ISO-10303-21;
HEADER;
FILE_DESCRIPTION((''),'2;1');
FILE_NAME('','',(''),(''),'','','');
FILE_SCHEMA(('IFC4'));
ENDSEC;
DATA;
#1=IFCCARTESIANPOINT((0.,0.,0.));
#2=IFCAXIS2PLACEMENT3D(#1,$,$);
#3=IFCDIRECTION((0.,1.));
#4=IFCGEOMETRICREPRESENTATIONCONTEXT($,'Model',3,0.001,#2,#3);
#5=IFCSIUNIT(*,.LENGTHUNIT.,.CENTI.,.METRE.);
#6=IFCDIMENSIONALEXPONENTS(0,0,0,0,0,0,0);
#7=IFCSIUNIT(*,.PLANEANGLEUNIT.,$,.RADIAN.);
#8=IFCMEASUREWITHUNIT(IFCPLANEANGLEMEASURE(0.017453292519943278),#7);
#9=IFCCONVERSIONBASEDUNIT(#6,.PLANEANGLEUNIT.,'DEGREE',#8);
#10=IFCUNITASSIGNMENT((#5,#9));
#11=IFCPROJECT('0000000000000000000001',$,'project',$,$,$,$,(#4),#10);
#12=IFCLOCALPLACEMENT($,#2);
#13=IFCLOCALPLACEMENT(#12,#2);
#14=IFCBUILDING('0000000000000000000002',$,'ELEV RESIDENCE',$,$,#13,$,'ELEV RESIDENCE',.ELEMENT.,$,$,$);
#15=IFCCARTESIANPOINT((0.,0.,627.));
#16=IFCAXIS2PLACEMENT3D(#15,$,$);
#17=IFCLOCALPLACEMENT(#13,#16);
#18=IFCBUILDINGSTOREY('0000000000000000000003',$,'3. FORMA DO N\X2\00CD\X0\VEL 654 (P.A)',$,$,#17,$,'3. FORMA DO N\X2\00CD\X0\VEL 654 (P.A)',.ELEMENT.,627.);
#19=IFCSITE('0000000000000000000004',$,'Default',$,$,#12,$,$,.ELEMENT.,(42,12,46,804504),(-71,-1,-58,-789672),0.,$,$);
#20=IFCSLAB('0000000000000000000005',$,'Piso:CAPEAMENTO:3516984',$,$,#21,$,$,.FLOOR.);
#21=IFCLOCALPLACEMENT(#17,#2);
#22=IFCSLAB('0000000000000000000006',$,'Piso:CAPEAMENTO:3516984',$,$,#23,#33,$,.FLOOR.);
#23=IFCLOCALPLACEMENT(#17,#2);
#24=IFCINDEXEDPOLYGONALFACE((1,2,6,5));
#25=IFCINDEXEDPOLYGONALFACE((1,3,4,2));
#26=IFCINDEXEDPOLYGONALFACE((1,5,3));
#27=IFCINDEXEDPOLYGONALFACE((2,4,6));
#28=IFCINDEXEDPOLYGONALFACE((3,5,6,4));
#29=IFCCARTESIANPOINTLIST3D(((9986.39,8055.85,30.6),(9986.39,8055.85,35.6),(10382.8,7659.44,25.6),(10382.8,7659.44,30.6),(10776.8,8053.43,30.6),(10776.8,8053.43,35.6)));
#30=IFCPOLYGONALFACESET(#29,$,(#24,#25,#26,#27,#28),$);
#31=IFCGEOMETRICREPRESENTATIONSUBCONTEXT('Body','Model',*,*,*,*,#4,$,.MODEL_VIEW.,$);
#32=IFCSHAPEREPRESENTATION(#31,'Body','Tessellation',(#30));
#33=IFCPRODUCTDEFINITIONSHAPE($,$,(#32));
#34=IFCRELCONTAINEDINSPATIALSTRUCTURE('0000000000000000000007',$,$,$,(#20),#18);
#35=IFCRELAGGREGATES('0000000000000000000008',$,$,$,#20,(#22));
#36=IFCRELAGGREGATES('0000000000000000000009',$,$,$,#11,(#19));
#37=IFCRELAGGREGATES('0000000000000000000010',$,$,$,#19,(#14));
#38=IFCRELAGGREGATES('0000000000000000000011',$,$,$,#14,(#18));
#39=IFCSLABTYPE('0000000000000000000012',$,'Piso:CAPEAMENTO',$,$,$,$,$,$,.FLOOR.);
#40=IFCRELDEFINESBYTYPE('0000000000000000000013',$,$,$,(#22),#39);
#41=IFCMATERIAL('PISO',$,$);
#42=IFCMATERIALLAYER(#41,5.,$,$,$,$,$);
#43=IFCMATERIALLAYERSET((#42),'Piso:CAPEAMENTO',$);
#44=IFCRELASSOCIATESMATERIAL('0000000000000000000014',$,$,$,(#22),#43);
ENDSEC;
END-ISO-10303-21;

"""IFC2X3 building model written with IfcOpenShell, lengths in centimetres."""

from ifc_helpers import new_model, entity, si_unit, converted_unit, direction, frame, origin, place, context, subcontext, project, spatial, polyline, outline, extrude, material, layer, layer_set, type_object, element, aggregate, save


model = new_model("IFC2X3")

# Units and contexts
model_context = context("Model", 3, precision=0.001, world=origin(), true_north=direction((0.0, 1.0)))
body_context = subcontext(model_context, "Body", "Model", "MODEL_VIEW")
ifc_project = project(units=[si_unit("LENGTHUNIT", "METRE", prefix="CENTI"), converted_unit("PLANEANGLEUNIT", "DEGREE", entity("IfcPlaneAngleMeasure", 0.017453292519943278), si_unit("PLANEANGLEUNIT", "RADIAN"), dimensions=[0, 0, 0, 0, 0, 0, 0])], contexts=[model_context])

# Site, building, storey
site_placement = place(None, origin())
site = spatial("IfcSite", under=ifc_project, at=site_placement, Name="Default", CompositionType="ELEMENT", RefLatitude=(42, 12, 46, 804504), RefLongitude=(-71, -1, -58, -789672), RefElevation=0.0)
building_placement = place(site_placement, origin())
building = spatial("IfcBuilding", under=site, at=building_placement, Name="ELEV RESIDENCE", LongName="ELEV RESIDENCE", CompositionType="ELEMENT")
storey_placement = place(building_placement, frame((0.0, 0.0, 627.0)))
storey = spatial("IfcBuildingStorey", under=building, at=storey_placement, Name="3. FORMA DO NÍVEL 654 (P.A)", LongName="3. FORMA DO NÍVEL 654 (P.A)", CompositionType="ELEMENT", Elevation=627.0)

# Slabs
slab_1_placement = place(storey_placement, frame((9186.8, 4986.44, 25.6)))
slab_1 = element("IfcSlab", 1, at=slab_1_placement, inside=storey, Name="Piso:CAPEAMENTO:3516984", PredefinedType="FLOOR")
ifc_material = material(Name="PISO")
ifc_layer = layer(ifc_material, 5.0)
ifc_layer_set = layer_set([ifc_layer], Name="Piso:CAPEAMENTO")
slab_type = type_object("IfcSlabType", Name="Piso:CAPEAMENTO", PredefinedType="FLOOR")
slab_2_placement = place(slab_1_placement, origin())
slab_2 = element("IfcSlab", 2, at=slab_2_placement, type_object=slab_type, material=ifc_layer_set, Name="Piso:CAPEAMENTO:3516984", PredefinedType="FLOOR", context=body_context, shape_type="SweptSolid", body=[
    extrude(outline(polyline([(1.22, -395.22), (395.22, -1.19), (-395.19, 1.22), (1.22, -395.22)])), frame((1194.78, 3068.19, 10.0), z_axis=(-0.000039, -0.012651, 0.99992), x_axis=(1.0, 0.0, 0.000039)), (-0.000039, -0.012651, -0.99992), 5.0),
])
aggregate(slab_1, [slab_2])

save(model, "model.ifc")
